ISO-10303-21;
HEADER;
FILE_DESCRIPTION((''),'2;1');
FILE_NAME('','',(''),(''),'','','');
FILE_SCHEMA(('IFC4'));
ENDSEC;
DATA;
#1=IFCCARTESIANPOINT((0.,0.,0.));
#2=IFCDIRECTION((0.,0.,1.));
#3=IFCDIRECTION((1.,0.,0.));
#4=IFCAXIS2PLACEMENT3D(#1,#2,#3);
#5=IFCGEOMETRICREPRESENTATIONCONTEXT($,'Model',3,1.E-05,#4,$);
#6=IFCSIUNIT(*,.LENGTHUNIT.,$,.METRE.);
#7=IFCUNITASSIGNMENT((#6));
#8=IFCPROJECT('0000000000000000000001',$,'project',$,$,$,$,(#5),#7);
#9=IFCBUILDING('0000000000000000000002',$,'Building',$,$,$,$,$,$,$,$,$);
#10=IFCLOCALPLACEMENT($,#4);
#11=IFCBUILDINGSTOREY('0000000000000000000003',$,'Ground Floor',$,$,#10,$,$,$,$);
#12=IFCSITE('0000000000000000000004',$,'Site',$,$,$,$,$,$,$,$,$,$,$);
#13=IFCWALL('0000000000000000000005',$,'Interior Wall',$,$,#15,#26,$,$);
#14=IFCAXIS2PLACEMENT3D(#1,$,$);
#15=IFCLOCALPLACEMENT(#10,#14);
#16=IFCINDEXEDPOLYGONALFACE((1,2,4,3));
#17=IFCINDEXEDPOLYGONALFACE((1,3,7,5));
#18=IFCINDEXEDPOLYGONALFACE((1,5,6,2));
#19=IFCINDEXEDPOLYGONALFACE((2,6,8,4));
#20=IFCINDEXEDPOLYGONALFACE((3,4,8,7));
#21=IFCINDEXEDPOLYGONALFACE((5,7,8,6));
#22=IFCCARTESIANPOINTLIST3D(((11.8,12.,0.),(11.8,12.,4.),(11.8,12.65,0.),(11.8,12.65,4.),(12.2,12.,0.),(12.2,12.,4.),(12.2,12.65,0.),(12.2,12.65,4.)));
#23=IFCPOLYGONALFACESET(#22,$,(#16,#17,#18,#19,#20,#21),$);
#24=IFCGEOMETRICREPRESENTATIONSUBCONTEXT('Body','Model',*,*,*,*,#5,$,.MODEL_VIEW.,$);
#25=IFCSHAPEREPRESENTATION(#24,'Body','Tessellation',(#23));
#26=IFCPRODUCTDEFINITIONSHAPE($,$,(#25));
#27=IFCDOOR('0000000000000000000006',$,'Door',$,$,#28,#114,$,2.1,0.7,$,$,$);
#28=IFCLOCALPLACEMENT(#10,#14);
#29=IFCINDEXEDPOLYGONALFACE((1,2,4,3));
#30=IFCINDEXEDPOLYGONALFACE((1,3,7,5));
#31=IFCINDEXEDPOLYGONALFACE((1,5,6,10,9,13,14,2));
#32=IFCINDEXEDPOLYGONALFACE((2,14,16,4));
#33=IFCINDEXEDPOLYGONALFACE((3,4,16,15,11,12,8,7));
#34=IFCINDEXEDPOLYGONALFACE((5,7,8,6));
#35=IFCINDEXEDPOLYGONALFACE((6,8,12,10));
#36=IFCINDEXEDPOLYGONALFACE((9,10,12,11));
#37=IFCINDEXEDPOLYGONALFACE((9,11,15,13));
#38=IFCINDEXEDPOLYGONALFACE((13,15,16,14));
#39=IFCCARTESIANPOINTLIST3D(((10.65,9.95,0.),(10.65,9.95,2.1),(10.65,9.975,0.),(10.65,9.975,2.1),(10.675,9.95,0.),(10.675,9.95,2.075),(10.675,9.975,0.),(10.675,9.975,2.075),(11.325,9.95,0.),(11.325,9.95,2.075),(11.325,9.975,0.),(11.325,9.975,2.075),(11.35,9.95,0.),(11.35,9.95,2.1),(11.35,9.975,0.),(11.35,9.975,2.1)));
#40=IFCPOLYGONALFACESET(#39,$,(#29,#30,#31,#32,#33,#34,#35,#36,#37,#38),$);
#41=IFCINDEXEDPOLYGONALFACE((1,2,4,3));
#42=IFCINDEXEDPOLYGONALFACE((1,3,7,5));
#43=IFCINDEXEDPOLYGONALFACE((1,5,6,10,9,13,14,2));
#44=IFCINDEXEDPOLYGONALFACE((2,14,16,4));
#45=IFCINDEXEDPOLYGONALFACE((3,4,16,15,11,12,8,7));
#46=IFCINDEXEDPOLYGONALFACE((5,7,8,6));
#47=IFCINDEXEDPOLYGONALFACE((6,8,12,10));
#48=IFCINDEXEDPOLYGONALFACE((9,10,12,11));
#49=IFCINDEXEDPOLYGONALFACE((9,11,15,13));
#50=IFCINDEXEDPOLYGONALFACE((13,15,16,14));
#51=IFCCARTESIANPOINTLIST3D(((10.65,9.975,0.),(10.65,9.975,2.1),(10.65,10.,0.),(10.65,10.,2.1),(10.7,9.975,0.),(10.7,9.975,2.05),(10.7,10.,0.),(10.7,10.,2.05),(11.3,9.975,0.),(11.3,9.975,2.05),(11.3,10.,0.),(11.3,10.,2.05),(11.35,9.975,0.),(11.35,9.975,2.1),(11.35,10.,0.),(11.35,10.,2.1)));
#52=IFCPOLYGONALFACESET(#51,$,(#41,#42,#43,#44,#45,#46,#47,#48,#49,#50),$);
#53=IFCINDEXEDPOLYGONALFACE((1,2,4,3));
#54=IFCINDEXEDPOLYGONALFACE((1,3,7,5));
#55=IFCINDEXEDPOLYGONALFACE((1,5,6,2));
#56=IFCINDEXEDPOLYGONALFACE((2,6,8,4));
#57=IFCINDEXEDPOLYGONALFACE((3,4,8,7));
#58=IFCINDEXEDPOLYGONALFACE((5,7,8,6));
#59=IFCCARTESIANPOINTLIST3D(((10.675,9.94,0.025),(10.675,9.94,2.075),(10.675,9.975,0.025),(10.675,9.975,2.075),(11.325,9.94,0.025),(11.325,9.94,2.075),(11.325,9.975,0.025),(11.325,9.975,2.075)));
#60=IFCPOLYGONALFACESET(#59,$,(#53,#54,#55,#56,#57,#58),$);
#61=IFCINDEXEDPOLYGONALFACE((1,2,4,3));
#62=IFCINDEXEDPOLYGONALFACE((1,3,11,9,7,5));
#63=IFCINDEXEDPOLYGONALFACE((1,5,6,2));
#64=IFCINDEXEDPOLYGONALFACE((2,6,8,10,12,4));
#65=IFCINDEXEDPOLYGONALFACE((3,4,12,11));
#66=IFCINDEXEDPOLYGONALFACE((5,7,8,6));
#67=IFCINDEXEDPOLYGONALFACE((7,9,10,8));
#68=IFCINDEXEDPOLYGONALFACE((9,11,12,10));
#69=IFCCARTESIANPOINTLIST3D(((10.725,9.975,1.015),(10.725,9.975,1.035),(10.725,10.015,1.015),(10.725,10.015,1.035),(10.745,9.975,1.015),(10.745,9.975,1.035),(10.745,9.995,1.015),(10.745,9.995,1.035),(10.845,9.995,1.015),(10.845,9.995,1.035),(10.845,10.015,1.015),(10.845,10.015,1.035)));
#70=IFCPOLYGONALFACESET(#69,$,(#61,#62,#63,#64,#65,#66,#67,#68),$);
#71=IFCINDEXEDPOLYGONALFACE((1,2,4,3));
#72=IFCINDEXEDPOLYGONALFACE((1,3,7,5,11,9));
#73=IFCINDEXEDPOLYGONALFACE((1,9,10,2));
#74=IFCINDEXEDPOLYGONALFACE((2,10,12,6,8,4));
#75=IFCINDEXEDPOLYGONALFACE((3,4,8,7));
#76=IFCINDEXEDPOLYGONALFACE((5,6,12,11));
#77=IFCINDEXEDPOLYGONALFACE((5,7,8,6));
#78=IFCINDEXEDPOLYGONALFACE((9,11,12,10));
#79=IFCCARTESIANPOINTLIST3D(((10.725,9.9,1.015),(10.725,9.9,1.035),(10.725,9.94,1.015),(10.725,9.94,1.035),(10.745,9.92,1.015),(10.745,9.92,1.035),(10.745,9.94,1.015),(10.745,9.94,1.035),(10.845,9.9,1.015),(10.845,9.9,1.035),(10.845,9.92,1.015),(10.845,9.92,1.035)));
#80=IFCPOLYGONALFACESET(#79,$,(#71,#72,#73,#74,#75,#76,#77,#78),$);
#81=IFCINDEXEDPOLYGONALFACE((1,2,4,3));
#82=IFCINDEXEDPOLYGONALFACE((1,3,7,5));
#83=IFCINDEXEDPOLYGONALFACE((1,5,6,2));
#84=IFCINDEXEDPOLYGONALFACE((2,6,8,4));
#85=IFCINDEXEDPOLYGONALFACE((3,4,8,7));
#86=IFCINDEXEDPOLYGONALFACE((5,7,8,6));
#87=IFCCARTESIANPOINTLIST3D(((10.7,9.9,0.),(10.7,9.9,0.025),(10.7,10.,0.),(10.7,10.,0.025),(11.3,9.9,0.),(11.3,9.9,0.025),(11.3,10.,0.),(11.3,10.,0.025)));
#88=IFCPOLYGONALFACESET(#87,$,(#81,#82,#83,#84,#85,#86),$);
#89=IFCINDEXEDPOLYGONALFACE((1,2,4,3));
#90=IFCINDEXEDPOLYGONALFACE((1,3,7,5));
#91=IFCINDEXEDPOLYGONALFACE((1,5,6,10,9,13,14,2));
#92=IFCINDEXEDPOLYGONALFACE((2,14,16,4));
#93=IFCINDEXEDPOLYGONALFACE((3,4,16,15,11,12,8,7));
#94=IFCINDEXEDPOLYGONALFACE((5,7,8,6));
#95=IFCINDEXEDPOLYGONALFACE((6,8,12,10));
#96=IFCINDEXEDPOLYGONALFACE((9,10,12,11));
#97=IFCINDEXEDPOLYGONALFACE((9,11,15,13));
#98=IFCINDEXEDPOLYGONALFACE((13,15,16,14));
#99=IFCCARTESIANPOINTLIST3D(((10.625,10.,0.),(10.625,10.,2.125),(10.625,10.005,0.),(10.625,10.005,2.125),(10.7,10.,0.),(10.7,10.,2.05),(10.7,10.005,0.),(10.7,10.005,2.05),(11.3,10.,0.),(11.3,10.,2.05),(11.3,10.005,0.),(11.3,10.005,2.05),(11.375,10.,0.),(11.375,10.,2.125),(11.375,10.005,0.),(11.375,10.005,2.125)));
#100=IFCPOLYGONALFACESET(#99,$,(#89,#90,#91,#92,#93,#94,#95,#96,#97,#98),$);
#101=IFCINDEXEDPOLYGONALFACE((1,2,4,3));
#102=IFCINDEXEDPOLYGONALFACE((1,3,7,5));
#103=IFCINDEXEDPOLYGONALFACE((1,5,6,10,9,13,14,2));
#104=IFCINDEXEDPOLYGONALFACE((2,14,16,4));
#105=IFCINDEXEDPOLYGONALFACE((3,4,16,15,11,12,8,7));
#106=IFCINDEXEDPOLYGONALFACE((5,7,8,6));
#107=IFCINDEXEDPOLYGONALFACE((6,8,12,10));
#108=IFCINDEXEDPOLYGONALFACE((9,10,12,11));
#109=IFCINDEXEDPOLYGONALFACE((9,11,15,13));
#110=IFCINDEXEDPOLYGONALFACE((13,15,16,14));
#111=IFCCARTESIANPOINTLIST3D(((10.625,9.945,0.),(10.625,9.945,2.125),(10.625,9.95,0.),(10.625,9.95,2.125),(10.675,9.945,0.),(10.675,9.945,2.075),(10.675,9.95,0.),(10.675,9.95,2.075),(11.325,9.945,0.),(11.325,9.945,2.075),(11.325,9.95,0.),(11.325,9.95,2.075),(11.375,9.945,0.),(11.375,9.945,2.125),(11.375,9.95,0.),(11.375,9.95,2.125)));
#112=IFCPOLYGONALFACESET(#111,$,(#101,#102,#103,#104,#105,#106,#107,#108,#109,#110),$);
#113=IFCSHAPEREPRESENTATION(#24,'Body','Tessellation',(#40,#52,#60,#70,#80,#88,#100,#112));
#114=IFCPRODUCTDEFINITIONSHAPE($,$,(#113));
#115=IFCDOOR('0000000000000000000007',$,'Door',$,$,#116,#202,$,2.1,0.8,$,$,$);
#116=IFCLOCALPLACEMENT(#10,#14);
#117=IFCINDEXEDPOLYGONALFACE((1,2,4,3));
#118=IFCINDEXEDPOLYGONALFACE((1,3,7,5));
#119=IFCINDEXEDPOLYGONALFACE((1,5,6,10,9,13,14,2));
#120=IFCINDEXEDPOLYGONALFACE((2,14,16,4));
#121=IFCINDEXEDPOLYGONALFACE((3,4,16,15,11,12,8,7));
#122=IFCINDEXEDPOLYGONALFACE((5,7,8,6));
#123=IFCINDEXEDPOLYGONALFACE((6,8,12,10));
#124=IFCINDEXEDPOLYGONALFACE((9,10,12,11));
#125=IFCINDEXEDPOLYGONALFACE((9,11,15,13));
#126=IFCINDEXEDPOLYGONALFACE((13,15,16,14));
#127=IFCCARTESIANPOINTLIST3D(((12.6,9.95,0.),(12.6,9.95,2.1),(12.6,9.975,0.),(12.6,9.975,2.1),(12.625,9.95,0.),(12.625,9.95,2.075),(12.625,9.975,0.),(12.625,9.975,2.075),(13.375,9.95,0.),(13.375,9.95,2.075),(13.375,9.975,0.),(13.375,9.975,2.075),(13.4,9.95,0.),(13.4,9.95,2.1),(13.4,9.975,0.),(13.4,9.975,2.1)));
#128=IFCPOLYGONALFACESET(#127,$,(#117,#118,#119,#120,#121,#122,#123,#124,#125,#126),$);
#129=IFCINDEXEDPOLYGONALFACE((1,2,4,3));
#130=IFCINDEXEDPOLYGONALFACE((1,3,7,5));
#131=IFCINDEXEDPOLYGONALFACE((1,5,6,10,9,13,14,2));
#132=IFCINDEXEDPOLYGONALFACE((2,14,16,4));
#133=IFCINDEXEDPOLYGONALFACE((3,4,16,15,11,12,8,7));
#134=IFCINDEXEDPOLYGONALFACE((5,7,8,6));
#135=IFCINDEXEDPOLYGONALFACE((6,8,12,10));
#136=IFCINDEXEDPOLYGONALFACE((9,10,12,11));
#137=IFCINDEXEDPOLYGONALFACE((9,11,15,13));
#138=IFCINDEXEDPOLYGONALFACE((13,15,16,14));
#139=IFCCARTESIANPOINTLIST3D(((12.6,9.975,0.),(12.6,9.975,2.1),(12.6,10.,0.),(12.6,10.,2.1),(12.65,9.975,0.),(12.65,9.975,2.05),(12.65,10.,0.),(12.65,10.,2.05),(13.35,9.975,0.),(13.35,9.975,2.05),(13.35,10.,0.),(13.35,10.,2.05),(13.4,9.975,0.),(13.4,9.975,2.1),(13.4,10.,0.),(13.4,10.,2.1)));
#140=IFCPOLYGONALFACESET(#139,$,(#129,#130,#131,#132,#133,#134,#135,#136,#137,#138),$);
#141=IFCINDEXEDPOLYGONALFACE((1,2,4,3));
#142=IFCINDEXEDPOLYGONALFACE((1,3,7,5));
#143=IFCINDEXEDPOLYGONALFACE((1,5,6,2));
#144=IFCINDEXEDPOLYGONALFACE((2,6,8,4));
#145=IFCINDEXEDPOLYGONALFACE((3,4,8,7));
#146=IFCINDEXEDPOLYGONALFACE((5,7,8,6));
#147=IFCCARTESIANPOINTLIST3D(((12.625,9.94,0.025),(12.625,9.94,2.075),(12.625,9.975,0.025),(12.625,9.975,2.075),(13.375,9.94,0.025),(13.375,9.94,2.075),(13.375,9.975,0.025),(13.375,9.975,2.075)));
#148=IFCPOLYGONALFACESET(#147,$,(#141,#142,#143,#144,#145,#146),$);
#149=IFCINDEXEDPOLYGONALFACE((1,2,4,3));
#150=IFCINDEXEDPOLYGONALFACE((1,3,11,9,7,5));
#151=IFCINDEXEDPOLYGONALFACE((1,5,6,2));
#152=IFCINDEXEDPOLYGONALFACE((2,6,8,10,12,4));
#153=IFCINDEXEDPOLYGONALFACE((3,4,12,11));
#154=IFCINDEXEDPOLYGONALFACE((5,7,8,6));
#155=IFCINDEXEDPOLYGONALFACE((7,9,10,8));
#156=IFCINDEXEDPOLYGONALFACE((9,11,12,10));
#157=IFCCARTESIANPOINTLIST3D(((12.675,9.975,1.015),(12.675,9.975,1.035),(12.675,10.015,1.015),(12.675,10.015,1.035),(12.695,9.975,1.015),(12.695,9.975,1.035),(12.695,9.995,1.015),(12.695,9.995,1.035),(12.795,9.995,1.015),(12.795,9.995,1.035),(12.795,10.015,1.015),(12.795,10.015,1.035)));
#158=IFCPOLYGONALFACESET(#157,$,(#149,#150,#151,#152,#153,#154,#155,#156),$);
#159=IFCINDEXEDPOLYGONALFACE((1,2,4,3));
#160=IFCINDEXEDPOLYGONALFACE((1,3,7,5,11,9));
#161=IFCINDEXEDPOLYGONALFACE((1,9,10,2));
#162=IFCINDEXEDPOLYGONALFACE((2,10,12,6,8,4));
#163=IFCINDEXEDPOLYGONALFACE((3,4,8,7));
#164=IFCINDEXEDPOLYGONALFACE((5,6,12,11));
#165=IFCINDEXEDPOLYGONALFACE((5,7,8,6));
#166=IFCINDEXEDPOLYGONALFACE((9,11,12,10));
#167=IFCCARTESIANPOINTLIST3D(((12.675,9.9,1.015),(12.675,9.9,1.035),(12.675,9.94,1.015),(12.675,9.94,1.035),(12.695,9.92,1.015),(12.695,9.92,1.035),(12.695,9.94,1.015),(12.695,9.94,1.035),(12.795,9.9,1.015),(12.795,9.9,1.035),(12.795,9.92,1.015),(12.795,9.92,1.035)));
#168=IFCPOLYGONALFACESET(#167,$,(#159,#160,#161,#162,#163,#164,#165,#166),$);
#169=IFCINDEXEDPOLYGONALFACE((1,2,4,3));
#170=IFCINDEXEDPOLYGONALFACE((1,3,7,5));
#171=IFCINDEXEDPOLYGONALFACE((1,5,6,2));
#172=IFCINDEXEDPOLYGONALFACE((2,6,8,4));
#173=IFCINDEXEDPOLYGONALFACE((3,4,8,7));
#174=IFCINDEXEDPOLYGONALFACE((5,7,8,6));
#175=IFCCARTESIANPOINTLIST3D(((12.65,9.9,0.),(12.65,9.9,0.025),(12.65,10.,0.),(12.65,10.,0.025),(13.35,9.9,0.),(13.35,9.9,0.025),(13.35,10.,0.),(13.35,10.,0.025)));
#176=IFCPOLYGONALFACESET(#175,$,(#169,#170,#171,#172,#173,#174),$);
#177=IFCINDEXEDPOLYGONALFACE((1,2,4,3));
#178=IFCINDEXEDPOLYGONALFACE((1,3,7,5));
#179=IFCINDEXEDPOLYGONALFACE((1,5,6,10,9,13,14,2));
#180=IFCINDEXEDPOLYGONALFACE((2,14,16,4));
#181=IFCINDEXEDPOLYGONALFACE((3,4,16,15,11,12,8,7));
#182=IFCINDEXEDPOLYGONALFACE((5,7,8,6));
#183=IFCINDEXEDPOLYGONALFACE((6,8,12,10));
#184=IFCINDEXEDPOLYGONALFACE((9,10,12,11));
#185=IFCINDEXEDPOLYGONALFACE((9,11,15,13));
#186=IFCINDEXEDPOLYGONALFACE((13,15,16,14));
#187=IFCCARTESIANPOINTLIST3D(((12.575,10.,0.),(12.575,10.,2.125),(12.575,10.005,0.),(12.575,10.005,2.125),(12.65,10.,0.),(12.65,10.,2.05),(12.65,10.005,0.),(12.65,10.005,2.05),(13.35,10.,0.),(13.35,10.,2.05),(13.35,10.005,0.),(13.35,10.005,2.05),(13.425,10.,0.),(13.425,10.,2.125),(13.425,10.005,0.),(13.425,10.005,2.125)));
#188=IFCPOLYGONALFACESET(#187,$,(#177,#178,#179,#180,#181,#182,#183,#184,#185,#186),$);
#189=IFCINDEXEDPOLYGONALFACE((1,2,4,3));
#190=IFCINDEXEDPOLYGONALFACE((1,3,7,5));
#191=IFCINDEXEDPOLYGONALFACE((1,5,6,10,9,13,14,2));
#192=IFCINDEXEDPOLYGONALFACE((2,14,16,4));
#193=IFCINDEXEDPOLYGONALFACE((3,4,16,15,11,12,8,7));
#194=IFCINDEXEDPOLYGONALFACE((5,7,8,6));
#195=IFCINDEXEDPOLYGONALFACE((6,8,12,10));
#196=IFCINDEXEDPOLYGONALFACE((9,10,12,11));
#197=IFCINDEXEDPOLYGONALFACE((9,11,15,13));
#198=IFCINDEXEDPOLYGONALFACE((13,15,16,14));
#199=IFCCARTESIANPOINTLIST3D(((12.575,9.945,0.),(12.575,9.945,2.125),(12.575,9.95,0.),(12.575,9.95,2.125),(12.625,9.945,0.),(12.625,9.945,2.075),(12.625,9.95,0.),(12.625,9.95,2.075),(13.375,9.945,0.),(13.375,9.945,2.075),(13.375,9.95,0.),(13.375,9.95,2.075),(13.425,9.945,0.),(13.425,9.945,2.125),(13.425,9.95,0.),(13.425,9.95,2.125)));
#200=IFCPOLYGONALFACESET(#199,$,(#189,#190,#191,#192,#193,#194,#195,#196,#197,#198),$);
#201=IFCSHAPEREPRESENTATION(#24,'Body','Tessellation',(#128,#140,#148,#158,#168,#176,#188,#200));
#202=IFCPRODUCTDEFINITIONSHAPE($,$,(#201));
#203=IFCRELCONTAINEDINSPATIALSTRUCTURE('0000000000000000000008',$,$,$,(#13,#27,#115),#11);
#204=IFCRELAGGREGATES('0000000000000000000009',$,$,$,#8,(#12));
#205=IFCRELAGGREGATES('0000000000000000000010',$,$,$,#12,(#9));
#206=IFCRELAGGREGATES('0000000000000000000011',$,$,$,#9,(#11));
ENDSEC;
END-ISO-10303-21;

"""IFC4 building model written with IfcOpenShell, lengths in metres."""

from ifc_helpers import new_model, si_unit, frame, origin_with_axes, place, context, subcontext, project, spatial, line, indexed_curve, outline, extrude, element, save


model = new_model("IFC4")

# Units and contexts
model_context = context("Model", 3, precision=1e-05, world=origin_with_axes())
body_context = subcontext(model_context, "Body", "Model", "MODEL_VIEW")
ifc_project = project(units=[si_unit("LENGTHUNIT", "METRE")], contexts=[model_context])

# Site, building, storey
site = spatial("IfcSite", under=ifc_project, Name="Site")
building = spatial("IfcBuilding", under=site, Name="Building")
storey_placement = place(None, origin_with_axes())
storey = spatial("IfcBuildingStorey", under=building, at=storey_placement, Name="Ground Floor")

# Wall
for number, where, z_axis, x_axis, name in (
    (1, (12.0, 12.65, 0.0), (0.0, 0.0, 1.0), (0.0, -1.0, 0.0), "Interior Wall"),
):
    element("IfcWall", number, at=place(storey_placement, frame(where, z_axis=z_axis, x_axis=x_axis)), inside=storey, Name=name, context=body_context, shape_type="SweptSolid", body=[
        extrude(outline(indexed_curve([(0.0, 0.0), (0.0, 0.4), (0.65, 0.4), (0.65, 0.0), (0.0, 0.0)], self_intersect=False)), frame((0.0, -0.2, 0.0), z_axis=(0.0, 0.0, 1.0), x_axis=(1.0, 0.0, 0.0)), (0.0, 0.0, 1.0), 4.0),
    ])

# Doors
door_1_placement = place(storey_placement, frame((11.35, 10.0, 0.0), z_axis=(0.0, 0.0, 1.0), x_axis=(-1.0, 0.0, 0.0)))
element("IfcDoor", 2, at=door_1_placement, inside=storey, Name="Door", OverallHeight=2.1, OverallWidth=0.7, context=body_context, shape_type="SweptSolid", body=[
    extrude(outline(indexed_curve([(0.0, 0.0), (0.0, 2.1), (0.7, 2.1), (0.7, 0.0), (0.675, 0.0), (0.675, 2.075), (0.025, 2.075), (0.025, 0.0)], segments=[line(1, 2, 3, 4, 5, 6, 7, 8, 1)])), frame((0.0, 0.025, 0.0), z_axis=(0.0, -1.0, 0.0), x_axis=(1.0, 0.0, 0.0)), (0.0, 0.0, -1.0), 0.025),
    extrude(outline(indexed_curve([(0.0, 0.0), (0.0, 2.1), (0.7, 2.1), (0.7, 0.0), (0.65, 0.0), (0.65, 2.05), (0.05, 2.05), (0.05, 0.0)], segments=[line(1, 2, 3, 4, 5, 6, 7, 8, 1)])), frame((0.0, 0.0, 0.0), z_axis=(0.0, -1.0, 0.0), x_axis=(1.0, 0.0, 0.0)), (0.0, 0.0, -1.0), 0.025),
    extrude(outline(indexed_curve([(0.0, 0.0), (0.65, 0.0), (0.65, 0.035), (0.0, 0.035)], segments=[line(1, 2, 3, 4, 1)])), frame((0.025, 0.025, 0.025), z_axis=(0.0, 0.0, 1.0), x_axis=(1.0, 0.0, 0.0)), (0.0, 0.0, 1.0), 2.05),
    extrude(outline(indexed_curve([(0.0, 0.0), (0.0, -0.04), (-0.12, -0.04), (-0.12, -0.02), (-0.02, -0.02), (-0.02, 0.0)], segments=[line(1, 2, 3, 4, 5, 6, 1)])), frame((0.625, 0.025, 1.015), z_axis=(0.0, 0.0, 1.0), x_axis=(1.0, 0.0, 0.0)), (0.0, 0.0, 1.0), 0.02),
    extrude(outline(indexed_curve([(0.0, 0.0), (0.0, 0.04), (-0.12, 0.04), (-0.12, 0.02), (-0.02, 0.02), (-0.02, 0.0)], segments=[line(1, 2, 3, 4, 5, 6, 1)])), frame((0.625, 0.06, 1.015), z_axis=(0.0, 0.0, 1.0), x_axis=(1.0, 0.0, 0.0)), (0.0, 0.0, 1.0), 0.02),
    extrude(outline(indexed_curve([(0.0, 0.0), (0.6, 0.0), (0.6, 0.1), (0.0, 0.1)], segments=[line(1, 2, 3, 4, 1)])), frame((0.05, 0.0, 0.0), z_axis=(0.0, 0.0, 1.0), x_axis=(1.0, 0.0, 0.0)), (0.0, 0.0, 1.0), 0.025),
    extrude(outline(indexed_curve([(0.0, 0.0), (0.0, 2.125), (0.75, 2.125), (0.75, 0.0), (0.675, 0.0), (0.675, 2.05), (0.075, 2.05), (0.075, 0.0)], segments=[line(1, 2, 3, 4, 5, 6, 7, 8, 1)])), frame((-0.025, -0.005, 0.0), z_axis=(0.0, -1.0, 0.0), x_axis=(1.0, 0.0, 0.0)), (0.0, 0.0, -1.0), 0.005),
    extrude(outline(indexed_curve([(0.0, 0.0), (0.0, 2.125), (0.75, 2.125), (0.75, 0.0), (0.7, 0.0), (0.7, 2.075), (0.05, 2.075), (0.05, 0.0)], segments=[line(1, 2, 3, 4, 5, 6, 7, 8, 1)])), frame((-0.025, 0.05, 0.0), z_axis=(0.0, -1.0, 0.0), x_axis=(1.0, 0.0, 0.0)), (0.0, 0.0, -1.0), 0.005),
])
door_2_placement = place(storey_placement, frame((13.4, 10.0, 0.0), z_axis=(0.0, 0.0, 1.0), x_axis=(-1.0, 0.0, 0.0)))
element("IfcDoor", 3, at=door_2_placement, inside=storey, Name="Door", OverallHeight=2.1, OverallWidth=0.8, context=body_context, shape_type="SweptSolid", body=[
    extrude(outline(indexed_curve([(0.0, 0.0), (0.0, 2.1), (0.8, 2.1), (0.8, 0.0), (0.775, 0.0), (0.775, 2.075), (0.025, 2.075), (0.025, 0.0)], segments=[line(1, 2, 3, 4, 5, 6, 7, 8, 1)])), frame((0.0, 0.025, 0.0), z_axis=(0.0, -1.0, 0.0), x_axis=(1.0, 0.0, 0.0)), (0.0, 0.0, -1.0), 0.025),
    extrude(outline(indexed_curve([(0.0, 0.0), (0.0, 2.1), (0.8, 2.1), (0.8, 0.0), (0.75, 0.0), (0.75, 2.05), (0.05, 2.05), (0.05, 0.0)], segments=[line(1, 2, 3, 4, 5, 6, 7, 8, 1)])), frame((0.0, 0.0, 0.0), z_axis=(0.0, -1.0, 0.0), x_axis=(1.0, 0.0, 0.0)), (0.0, 0.0, -1.0), 0.025),
    extrude(outline(indexed_curve([(0.0, 0.0), (0.75, 0.0), (0.75, 0.035), (0.0, 0.035)], segments=[line(1, 2, 3, 4, 1)])), frame((0.025, 0.025, 0.025), z_axis=(0.0, 0.0, 1.0), x_axis=(1.0, 0.0, 0.0)), (0.0, 0.0, 1.0), 2.05),
    extrude(outline(indexed_curve([(0.0, 0.0), (0.0, -0.04), (-0.12, -0.04), (-0.12, -0.02), (-0.02, -0.02), (-0.02, 0.0)], segments=[line(1, 2, 3, 4, 5, 6, 1)])), frame((0.725, 0.025, 1.015), z_axis=(0.0, 0.0, 1.0), x_axis=(1.0, 0.0, 0.0)), (0.0, 0.0, 1.0), 0.02),
    extrude(outline(indexed_curve([(0.0, 0.0), (0.0, 0.04), (-0.12, 0.04), (-0.12, 0.02), (-0.02, 0.02), (-0.02, 0.0)], segments=[line(1, 2, 3, 4, 5, 6, 1)])), frame((0.725, 0.06, 1.015), z_axis=(0.0, 0.0, 1.0), x_axis=(1.0, 0.0, 0.0)), (0.0, 0.0, 1.0), 0.02),
    extrude(outline(indexed_curve([(0.0, 0.0), (0.7, 0.0), (0.7, 0.1), (0.0, 0.1)], segments=[line(1, 2, 3, 4, 1)])), frame((0.05, 0.0, 0.0), z_axis=(0.0, 0.0, 1.0), x_axis=(1.0, 0.0, 0.0)), (0.0, 0.0, 1.0), 0.025),
    extrude(outline(indexed_curve([(0.0, 0.0), (0.0, 2.125), (0.85, 2.125), (0.85, 0.0), (0.775, 0.0), (0.775, 2.05), (0.075, 2.05), (0.075, 0.0)], segments=[line(1, 2, 3, 4, 5, 6, 7, 8, 1)])), frame((-0.025, -0.005, 0.0), z_axis=(0.0, -1.0, 0.0), x_axis=(1.0, 0.0, 0.0)), (0.0, 0.0, -1.0), 0.005),
    extrude(outline(indexed_curve([(0.0, 0.0), (0.0, 2.125), (0.85, 2.125), (0.85, 0.0), (0.8, 0.0), (0.8, 2.075), (0.05, 2.075), (0.05, 0.0)], segments=[line(1, 2, 3, 4, 5, 6, 7, 8, 1)])), frame((-0.025, 0.05, 0.0), z_axis=(0.0, -1.0, 0.0), x_axis=(1.0, 0.0, 0.0)), (0.0, 0.0, -1.0), 0.005),
])

save(model, "model.ifc")
